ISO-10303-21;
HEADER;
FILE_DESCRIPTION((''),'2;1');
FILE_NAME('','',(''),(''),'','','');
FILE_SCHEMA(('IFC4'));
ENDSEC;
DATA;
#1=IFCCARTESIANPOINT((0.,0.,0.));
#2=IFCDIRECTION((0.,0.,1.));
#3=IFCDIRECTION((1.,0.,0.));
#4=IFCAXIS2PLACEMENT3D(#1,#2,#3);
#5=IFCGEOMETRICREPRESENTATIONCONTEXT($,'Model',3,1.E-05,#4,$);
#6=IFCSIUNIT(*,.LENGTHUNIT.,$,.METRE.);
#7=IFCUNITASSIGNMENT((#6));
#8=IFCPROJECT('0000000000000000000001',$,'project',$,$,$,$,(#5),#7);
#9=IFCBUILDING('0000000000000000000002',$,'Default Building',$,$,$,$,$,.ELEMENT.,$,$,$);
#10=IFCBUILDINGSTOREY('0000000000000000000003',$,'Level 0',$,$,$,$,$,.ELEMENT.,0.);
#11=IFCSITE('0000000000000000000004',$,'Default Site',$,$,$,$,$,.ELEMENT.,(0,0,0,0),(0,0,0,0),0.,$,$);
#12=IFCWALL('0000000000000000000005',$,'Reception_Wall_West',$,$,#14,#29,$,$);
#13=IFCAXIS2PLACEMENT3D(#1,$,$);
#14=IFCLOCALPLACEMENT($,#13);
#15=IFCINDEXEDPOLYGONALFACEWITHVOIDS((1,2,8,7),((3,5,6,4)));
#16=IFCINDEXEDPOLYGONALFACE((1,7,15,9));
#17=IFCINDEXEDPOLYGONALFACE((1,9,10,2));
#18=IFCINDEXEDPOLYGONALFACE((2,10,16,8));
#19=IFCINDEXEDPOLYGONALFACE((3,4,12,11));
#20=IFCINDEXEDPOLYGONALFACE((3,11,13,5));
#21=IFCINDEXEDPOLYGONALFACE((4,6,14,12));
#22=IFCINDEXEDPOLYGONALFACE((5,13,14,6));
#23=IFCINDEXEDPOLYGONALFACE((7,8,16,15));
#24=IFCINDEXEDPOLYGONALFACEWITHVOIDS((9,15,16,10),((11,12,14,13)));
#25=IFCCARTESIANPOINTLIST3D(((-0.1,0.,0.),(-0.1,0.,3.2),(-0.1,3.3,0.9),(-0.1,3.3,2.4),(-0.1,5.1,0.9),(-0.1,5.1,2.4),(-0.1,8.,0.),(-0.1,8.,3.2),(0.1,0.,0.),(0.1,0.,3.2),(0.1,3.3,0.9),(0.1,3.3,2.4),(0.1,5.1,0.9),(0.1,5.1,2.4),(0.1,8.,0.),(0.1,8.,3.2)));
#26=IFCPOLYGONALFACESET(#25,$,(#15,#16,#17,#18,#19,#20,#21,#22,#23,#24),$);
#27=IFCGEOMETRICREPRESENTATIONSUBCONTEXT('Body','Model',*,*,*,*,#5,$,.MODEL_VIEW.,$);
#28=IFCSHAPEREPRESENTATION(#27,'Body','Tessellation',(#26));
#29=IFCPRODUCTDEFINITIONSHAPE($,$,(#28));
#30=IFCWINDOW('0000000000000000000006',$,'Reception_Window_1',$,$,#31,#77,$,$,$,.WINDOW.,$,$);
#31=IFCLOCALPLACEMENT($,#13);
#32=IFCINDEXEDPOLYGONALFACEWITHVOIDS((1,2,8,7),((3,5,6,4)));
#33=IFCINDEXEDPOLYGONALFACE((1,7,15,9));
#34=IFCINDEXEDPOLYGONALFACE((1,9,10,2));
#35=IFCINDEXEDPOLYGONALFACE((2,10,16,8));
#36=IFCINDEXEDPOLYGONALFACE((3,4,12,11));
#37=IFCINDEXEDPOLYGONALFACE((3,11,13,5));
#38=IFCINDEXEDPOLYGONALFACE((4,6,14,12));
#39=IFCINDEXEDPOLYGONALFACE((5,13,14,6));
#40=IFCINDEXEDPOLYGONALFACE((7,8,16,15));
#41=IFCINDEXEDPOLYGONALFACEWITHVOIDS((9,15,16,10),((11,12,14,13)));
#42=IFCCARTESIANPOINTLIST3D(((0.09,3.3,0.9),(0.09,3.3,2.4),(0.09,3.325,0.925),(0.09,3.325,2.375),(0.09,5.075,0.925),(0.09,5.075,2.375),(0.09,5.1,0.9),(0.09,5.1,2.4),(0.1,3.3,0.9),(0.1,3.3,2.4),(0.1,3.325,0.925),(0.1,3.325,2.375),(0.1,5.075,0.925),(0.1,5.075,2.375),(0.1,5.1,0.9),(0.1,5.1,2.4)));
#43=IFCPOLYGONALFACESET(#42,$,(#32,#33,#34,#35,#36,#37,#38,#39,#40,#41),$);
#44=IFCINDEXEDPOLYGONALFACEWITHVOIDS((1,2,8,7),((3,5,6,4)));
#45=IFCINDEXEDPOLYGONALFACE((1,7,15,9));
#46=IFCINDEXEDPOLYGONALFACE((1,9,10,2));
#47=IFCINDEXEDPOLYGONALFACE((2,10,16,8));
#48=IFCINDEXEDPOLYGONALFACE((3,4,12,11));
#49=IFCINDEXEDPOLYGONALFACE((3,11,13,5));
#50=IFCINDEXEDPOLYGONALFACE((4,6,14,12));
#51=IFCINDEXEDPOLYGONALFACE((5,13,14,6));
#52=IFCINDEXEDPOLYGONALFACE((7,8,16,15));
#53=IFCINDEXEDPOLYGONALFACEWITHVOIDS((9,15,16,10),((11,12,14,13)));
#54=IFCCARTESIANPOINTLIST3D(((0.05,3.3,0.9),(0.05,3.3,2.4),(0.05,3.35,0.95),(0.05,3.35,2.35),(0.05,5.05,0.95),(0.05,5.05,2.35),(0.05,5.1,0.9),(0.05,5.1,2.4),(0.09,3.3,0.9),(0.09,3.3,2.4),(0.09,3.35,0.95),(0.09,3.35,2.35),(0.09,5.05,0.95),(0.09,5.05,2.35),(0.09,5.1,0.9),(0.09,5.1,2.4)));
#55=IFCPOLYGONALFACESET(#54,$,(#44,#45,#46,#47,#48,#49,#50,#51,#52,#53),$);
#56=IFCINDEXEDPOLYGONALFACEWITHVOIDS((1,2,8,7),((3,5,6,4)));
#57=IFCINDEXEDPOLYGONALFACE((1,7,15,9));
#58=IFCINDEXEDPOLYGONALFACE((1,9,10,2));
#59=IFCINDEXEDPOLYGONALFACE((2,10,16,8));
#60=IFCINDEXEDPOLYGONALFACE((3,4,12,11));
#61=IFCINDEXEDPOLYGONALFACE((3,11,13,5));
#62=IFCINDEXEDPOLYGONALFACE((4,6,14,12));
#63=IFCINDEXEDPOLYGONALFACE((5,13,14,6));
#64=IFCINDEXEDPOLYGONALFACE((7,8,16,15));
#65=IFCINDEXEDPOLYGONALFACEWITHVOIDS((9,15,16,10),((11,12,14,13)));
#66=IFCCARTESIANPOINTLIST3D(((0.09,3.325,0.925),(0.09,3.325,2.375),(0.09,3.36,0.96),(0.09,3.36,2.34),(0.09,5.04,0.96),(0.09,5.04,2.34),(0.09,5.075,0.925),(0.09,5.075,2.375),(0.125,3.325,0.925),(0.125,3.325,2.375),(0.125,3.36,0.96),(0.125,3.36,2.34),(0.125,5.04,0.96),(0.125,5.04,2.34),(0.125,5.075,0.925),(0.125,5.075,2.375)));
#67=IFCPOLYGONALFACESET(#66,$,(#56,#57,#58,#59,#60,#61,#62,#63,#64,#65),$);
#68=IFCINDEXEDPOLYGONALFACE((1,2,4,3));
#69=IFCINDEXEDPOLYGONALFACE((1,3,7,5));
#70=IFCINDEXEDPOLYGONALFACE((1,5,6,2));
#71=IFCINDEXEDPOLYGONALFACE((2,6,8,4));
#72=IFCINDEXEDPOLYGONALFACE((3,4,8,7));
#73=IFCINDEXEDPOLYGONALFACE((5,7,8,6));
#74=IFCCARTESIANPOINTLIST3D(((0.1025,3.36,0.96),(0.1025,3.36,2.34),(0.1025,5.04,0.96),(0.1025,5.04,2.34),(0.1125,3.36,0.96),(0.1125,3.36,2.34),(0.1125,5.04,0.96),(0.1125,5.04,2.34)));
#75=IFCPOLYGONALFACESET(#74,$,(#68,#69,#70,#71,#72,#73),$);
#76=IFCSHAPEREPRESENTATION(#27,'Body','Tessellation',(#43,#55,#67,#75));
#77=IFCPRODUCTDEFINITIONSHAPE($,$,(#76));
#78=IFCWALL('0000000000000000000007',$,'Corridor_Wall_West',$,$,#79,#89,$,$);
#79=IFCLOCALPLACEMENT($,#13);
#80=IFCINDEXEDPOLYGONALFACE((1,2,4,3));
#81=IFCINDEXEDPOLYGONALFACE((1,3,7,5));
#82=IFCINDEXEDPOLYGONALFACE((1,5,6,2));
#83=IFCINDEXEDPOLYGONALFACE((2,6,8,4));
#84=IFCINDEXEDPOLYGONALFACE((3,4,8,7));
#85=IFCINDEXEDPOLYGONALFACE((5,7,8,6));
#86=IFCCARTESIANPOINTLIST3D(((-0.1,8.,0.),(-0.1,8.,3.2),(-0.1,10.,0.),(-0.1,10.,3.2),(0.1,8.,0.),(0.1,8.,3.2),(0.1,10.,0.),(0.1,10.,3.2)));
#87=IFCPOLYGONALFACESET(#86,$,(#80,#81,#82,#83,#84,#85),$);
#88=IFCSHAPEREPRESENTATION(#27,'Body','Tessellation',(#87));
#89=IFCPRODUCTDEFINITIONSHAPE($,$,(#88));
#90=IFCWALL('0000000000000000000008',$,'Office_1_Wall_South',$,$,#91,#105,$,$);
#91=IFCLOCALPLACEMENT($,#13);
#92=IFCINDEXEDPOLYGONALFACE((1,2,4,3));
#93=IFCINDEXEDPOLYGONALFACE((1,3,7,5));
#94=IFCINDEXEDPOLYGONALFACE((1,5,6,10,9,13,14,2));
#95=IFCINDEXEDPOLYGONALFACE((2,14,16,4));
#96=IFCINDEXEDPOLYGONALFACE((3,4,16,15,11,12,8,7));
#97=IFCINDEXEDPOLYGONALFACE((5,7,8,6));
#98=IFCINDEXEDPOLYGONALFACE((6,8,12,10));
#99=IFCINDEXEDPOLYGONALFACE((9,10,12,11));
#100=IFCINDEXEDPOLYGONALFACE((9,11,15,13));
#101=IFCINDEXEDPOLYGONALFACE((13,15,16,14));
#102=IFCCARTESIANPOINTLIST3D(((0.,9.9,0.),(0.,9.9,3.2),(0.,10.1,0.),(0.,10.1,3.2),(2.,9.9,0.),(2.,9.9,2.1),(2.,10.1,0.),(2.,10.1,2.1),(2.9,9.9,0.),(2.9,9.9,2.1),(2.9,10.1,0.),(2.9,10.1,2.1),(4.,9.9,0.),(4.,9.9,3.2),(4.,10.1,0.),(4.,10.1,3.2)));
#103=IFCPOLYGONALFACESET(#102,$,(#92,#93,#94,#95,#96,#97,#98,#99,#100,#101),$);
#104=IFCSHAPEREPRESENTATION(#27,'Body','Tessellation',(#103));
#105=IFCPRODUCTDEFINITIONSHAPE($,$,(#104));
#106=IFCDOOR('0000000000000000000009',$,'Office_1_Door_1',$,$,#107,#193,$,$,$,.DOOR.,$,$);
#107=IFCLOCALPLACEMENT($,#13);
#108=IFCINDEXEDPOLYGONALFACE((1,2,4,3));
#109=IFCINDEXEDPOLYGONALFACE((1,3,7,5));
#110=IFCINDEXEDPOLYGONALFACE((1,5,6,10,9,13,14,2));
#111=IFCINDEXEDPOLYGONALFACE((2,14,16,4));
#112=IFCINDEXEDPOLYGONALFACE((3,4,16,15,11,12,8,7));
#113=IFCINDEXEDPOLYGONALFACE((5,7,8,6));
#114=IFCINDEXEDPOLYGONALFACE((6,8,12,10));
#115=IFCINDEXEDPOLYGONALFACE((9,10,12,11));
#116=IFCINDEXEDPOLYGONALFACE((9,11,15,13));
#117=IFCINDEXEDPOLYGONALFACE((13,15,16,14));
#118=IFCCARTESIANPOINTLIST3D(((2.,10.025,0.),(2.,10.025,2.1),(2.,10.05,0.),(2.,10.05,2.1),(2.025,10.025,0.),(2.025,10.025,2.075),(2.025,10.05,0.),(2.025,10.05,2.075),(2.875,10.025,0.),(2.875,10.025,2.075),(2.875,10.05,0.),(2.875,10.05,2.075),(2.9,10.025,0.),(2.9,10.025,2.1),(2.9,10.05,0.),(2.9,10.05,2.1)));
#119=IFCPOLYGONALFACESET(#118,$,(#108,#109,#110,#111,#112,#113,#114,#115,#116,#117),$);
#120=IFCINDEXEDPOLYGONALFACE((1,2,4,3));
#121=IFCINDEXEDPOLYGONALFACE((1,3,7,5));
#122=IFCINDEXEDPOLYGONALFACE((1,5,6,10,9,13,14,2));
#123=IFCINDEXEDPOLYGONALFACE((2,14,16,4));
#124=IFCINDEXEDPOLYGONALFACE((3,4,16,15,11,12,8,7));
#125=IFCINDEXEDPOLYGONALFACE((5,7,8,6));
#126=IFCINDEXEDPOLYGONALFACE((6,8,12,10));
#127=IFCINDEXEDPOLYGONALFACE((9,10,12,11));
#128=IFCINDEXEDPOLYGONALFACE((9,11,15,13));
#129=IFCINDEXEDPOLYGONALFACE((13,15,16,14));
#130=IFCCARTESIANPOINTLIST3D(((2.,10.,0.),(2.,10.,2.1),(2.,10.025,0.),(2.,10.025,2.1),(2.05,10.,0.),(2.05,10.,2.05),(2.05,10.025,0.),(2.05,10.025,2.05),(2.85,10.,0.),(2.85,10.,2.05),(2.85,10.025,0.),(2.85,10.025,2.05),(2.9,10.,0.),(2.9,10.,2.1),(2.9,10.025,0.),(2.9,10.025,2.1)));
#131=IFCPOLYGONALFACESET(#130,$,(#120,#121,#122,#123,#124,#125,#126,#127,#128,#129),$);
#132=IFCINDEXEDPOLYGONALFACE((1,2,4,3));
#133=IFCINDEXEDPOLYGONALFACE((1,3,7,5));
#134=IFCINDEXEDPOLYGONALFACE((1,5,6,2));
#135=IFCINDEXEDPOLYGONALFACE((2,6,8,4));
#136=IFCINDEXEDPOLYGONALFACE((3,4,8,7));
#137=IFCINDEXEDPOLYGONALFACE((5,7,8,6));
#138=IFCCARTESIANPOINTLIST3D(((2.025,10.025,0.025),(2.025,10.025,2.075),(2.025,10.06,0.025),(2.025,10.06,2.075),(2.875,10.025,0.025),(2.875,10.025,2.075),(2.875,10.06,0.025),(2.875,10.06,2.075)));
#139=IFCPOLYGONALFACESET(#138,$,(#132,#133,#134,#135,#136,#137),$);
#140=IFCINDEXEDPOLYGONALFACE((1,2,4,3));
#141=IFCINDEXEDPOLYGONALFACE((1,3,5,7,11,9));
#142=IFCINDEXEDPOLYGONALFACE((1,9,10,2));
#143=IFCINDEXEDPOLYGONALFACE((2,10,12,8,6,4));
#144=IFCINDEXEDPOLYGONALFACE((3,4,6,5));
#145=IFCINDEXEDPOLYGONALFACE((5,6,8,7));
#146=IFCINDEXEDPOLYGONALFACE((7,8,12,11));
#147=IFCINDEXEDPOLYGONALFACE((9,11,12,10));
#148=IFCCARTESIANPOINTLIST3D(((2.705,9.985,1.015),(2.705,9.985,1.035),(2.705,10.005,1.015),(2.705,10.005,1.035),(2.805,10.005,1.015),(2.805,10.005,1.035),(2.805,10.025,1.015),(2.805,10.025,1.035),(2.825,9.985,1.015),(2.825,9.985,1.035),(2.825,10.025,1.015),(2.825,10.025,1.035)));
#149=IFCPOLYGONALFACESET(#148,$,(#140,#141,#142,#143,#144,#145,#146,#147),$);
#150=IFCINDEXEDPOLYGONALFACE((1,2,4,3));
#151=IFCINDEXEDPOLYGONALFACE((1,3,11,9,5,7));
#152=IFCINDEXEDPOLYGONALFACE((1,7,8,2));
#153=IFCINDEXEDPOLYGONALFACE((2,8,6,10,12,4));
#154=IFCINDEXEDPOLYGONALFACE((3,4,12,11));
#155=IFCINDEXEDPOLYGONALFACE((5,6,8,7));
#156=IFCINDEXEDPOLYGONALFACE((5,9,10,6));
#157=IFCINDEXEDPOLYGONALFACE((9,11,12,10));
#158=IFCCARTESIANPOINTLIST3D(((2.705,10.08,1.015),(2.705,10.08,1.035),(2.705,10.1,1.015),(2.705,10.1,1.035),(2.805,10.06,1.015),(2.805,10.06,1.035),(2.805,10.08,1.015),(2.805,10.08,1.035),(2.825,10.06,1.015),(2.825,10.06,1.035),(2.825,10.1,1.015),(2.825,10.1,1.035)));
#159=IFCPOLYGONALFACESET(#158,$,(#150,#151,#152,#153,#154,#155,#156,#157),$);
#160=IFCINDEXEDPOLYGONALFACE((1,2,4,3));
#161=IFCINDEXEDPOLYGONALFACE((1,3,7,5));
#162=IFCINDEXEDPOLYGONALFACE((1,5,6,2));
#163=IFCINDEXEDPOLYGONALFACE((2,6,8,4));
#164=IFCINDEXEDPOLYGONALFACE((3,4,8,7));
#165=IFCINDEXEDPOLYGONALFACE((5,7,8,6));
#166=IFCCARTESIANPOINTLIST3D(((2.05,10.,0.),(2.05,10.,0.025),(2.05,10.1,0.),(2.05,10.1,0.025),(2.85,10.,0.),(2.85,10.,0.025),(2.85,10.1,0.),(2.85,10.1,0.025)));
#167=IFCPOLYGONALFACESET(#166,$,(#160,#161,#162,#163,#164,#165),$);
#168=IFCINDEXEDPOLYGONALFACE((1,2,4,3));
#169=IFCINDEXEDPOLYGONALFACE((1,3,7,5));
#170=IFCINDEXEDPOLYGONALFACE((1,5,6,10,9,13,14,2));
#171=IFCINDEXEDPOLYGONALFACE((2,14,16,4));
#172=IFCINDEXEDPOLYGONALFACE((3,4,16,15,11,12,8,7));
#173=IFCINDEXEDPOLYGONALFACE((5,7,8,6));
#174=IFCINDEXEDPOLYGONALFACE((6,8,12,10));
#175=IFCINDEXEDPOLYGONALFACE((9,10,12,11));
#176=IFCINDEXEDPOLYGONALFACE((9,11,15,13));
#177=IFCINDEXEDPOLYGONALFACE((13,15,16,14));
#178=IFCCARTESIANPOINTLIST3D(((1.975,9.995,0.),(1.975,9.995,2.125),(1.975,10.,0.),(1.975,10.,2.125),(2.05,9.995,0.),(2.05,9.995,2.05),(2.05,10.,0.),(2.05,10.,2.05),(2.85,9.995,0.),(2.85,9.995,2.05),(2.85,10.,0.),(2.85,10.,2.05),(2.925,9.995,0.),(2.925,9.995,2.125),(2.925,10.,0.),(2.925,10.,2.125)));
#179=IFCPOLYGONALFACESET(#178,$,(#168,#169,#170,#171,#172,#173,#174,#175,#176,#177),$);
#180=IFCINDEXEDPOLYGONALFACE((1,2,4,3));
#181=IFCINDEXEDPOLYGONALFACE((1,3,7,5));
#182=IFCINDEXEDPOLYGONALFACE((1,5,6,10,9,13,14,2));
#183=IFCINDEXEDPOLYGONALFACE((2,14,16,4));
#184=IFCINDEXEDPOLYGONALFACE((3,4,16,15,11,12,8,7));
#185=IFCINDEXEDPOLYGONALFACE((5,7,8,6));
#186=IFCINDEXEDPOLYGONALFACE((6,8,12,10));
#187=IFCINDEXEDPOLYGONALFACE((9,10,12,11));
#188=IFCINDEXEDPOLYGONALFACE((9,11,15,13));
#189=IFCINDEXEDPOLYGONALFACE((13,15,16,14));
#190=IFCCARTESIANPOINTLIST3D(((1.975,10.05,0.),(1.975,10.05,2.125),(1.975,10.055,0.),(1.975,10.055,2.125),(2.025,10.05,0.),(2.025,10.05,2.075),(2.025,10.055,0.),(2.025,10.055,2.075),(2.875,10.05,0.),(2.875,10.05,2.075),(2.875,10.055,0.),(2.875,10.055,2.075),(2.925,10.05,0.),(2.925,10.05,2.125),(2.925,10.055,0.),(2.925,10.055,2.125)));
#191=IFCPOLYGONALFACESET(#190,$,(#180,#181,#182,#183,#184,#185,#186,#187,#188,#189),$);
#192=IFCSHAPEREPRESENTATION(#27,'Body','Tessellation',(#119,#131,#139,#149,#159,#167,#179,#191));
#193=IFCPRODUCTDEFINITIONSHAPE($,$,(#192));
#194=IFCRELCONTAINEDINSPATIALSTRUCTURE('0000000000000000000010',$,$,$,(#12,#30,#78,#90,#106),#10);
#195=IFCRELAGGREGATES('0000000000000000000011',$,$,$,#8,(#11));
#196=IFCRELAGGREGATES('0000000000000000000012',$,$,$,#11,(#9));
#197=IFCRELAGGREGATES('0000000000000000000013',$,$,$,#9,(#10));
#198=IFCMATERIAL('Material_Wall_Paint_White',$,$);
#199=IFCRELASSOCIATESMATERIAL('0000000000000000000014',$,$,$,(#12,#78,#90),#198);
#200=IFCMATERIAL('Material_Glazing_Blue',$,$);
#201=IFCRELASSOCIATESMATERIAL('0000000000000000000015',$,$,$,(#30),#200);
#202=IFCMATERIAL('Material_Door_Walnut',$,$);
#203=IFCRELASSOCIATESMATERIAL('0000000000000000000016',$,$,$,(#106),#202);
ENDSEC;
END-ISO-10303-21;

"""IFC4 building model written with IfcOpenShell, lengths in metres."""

from ifc_helpers import new_model, si_unit, frame, origin_with_axes, place, context, subcontext, project, spatial, line, indexed_curve, outline, extrude, material, element, fill, save


model = new_model("IFC4")

# Units and contexts
model_context = context("Model", 3, precision=1e-05, world=origin_with_axes())
body_context = subcontext(model_context, "Body", "Model", "MODEL_VIEW")
ifc_project = project(units=[si_unit("LENGTHUNIT", "METRE")], contexts=[model_context])

# Site, building, storey
site = spatial("IfcSite", under=ifc_project, Name="Default Site", CompositionType="ELEMENT", RefLatitude=(0, 0, 0, 0), RefLongitude=(0, 0, 0, 0), RefElevation=0.0)
building = spatial("IfcBuilding", under=site, Name="Default Building", CompositionType="ELEMENT")
storey = spatial("IfcBuildingStorey", under=building, Name="Level 0", CompositionType="ELEMENT", Elevation=0.0)

# Shared definitions
ifc_material_1 = material(Name="Material_Wall_Paint_White")
ifc_material_2 = material(Name="Material_Door_Walnut")

# Wall, opening, window
wall_1_placement = place(None, frame((0.0, 8.0, 0.0), z_axis=(0.0, 0.0, 1.0), x_axis=(0.0, -1.0, 0.0)))
wall_1 = element("IfcWall", 1, at=wall_1_placement, inside=storey, material=ifc_material_1, Name="Reception_Wall_West", context=body_context, shape_type="SweptSolid", body=[
    extrude(outline(indexed_curve([(0.0, 0.0), (0.0, 0.2), (8.0, 0.2), (8.0, 0.0), (0.0, 0.0)], self_intersect=False)), frame((0.0, -0.1, 0.0), z_axis=(0.0, 0.0, 1.0), x_axis=(1.0, 0.0, 0.0)), (0.0, 0.0, 1.0), 3.2),
])
opening_1_placement = place(wall_1_placement, frame((2.9, -0.5, 0.9), z_axis=(0.0, 0.0, 1.0), x_axis=(1.0, 0.0, 0.0)))
opening_1 = element("IfcOpeningElement", 2, at=opening_1_placement, inside=storey, cuts=wall_1, PredefinedType="OPENING", context=body_context, shape_type="SweptSolid", body=[
    extrude(outline(indexed_curve([(0.0, 0.0), (0.0, 1.0), (1.8, 1.0), (1.8, 0.0), (0.0, 0.0)], self_intersect=False)), origin_with_axes(), (0.0, 0.0, 1.0), 1.5),
])
ifc_material_3 = material(Name="Material_Glazing_Blue")
window_placement = place(None, frame((0.0, 5.1, 0.9), z_axis=(0.0, 0.0, 1.0), x_axis=(0.0, -1.0, 0.0)))
window = element("IfcWindow", 3, at=window_placement, inside=storey, material=ifc_material_3, Name="Reception_Window_1", PredefinedType="WINDOW", context=body_context, shape_type="SweptSolid", body=[
    extrude(outline(indexed_curve([(0.0, 0.0), (1.8, 0.0), (1.8, 1.5), (0.0, 1.5)], segments=[line(1, 2, 3, 4, 1)]), holes=[indexed_curve([(0.025, 0.025), (1.775, 0.025), (1.775, 1.475), (0.025, 1.475)], segments=[line(1, 2, 3, 4, 1)])]), frame((0.0, 0.09, 0.0), z_axis=(0.0, -1.0, 0.0), x_axis=(1.0, 0.0, 0.0)), (0.0, 0.0, -1.0), 0.01),
    extrude(outline(indexed_curve([(0.0, 0.0), (1.8, 0.0), (1.8, 1.5), (0.0, 1.5)], segments=[line(1, 2, 3, 4, 1)]), holes=[indexed_curve([(0.05, 0.05), (1.75, 0.05), (1.75, 1.45), (0.05, 1.45)], segments=[line(1, 2, 3, 4, 1)])]), frame((0.0, 0.05, 0.0), z_axis=(0.0, -1.0, 0.0), x_axis=(1.0, 0.0, 0.0)), (0.0, 0.0, -1.0), 0.04),
    extrude(outline(indexed_curve([(0.0, 0.0), (1.75, 0.0), (1.75, 1.45), (0.0, 1.45)], segments=[line(1, 2, 3, 4, 1)]), holes=[indexed_curve([(0.035, 0.035), (1.715, 0.035), (1.715, 1.415), (0.035, 1.415)], segments=[line(1, 2, 3, 4, 1)])]), frame((0.025, 0.09, 0.025), z_axis=(0.0, -1.0, 0.0), x_axis=(1.0, 0.0, 0.0)), (0.0, 0.0, -1.0), 0.035),
    extrude(outline(indexed_curve([(0.035, 0.035), (1.715, 0.035), (1.715, 1.415), (0.035, 1.415)], segments=[line(1, 2, 3, 4, 1)])), frame((0.025, 0.1025, 0.025), z_axis=(0.0, -1.0, 0.0), x_axis=(1.0, 0.0, 0.0)), (0.0, 0.0, -1.0), 0.01),
])
fill(opening_1, window)

# Wall
wall_2_placement = place(None, frame((0.0, 10.0, 0.0), z_axis=(0.0, 0.0, 1.0), x_axis=(0.0, -1.0, 0.0)))
element("IfcWall", 4, at=wall_2_placement, inside=storey, material=ifc_material_1, Name="Corridor_Wall_West", context=body_context, shape_type="SweptSolid", body=[
    extrude(outline(indexed_curve([(0.0, 0.0), (0.0, 0.2), (2.0, 0.2), (2.0, 0.0), (0.0, 0.0)], self_intersect=False)), frame((0.0, -0.1, 0.0), z_axis=(0.0, 0.0, 1.0), x_axis=(1.0, 0.0, 0.0)), (0.0, 0.0, 1.0), 3.2),
])

# Wall, opening, door
wall_3_placement = place(None, frame((0.0, 10.0, 0.0), z_axis=(0.0, 0.0, 1.0), x_axis=(1.0, 0.0, 0.0)))
wall_3 = element("IfcWall", 5, at=wall_3_placement, inside=storey, material=ifc_material_1, Name="Office_1_Wall_South", context=body_context, shape_type="SweptSolid", body=[
    extrude(outline(indexed_curve([(0.0, 0.0), (0.0, 0.2), (4.0, 0.2), (4.0, 0.0), (0.0, 0.0)], self_intersect=False)), frame((0.0, -0.1, 0.0), z_axis=(0.0, 0.0, 1.0), x_axis=(1.0, 0.0, 0.0)), (0.0, 0.0, 1.0), 3.2),
])
opening_2_placement = place(wall_3_placement, frame((2.0, -0.5, 0.0), z_axis=(0.0, 0.0, 1.0), x_axis=(1.0, 0.0, 0.0)))
opening_2 = element("IfcOpeningElement", 6, at=opening_2_placement, inside=storey, cuts=wall_3, PredefinedType="OPENING", context=body_context, shape_type="SweptSolid", body=[
    extrude(outline(indexed_curve([(0.0, 0.0), (0.0, 1.0), (0.9, 1.0), (0.9, 0.0), (0.0, 0.0)], self_intersect=False)), origin_with_axes(), (0.0, 0.0, 1.0), 2.1),
])
door_1_placement = place(None, frame((2.0, 10.0, 0.0), z_axis=(0.0, 0.0, 1.0), x_axis=(1.0, 0.0, 0.0)))
door_1 = element("IfcDoor", 7, at=door_1_placement, inside=storey, material=ifc_material_2, Name="Office_1_Door_1", PredefinedType="DOOR", context=body_context, shape_type="SweptSolid", body=[
    extrude(outline(indexed_curve([(0.0, 0.0), (0.0, 2.1), (0.9, 2.1), (0.9, 0.0), (0.875, 0.0), (0.875, 2.075), (0.025, 2.075), (0.025, 0.0)], segments=[line(1, 2, 3, 4, 5, 6, 7, 8, 1)])), frame((0.0, 0.025, 0.0), z_axis=(0.0, -1.0, 0.0), x_axis=(1.0, 0.0, 0.0)), (0.0, 0.0, -1.0), 0.025),
    extrude(outline(indexed_curve([(0.0, 0.0), (0.0, 2.1), (0.9, 2.1), (0.9, 0.0), (0.85, 0.0), (0.85, 2.05), (0.05, 2.05), (0.05, 0.0)], segments=[line(1, 2, 3, 4, 5, 6, 7, 8, 1)])), frame((0.0, 0.0, 0.0), z_axis=(0.0, -1.0, 0.0), x_axis=(1.0, 0.0, 0.0)), (0.0, 0.0, -1.0), 0.025),
    extrude(outline(indexed_curve([(0.0, 0.0), (0.85, 0.0), (0.85, 0.035), (0.0, 0.035)], segments=[line(1, 2, 3, 4, 1)])), frame((0.025, 0.025, 0.025), z_axis=(0.0, 0.0, 1.0), x_axis=(1.0, 0.0, 0.0)), (0.0, 0.0, 1.0), 2.05),
    extrude(outline(indexed_curve([(0.0, 0.0), (0.0, -0.04), (-0.12, -0.04), (-0.12, -0.02), (-0.02, -0.02), (-0.02, 0.0)], segments=[line(1, 2, 3, 4, 5, 6, 1)])), frame((0.825, 0.025, 1.015), z_axis=(0.0, 0.0, 1.0), x_axis=(1.0, 0.0, 0.0)), (0.0, 0.0, 1.0), 0.02),
    extrude(outline(indexed_curve([(0.0, 0.0), (0.0, 0.04), (-0.12, 0.04), (-0.12, 0.02), (-0.02, 0.02), (-0.02, 0.0)], segments=[line(1, 2, 3, 4, 5, 6, 1)])), frame((0.825, 0.06, 1.015), z_axis=(0.0, 0.0, 1.0), x_axis=(1.0, 0.0, 0.0)), (0.0, 0.0, 1.0), 0.02),
    extrude(outline(indexed_curve([(0.0, 0.0), (0.8, 0.0), (0.8, 0.1), (0.0, 0.1)], segments=[line(1, 2, 3, 4, 1)])), frame((0.05, 0.0, 0.0), z_axis=(0.0, 0.0, 1.0), x_axis=(1.0, 0.0, 0.0)), (0.0, 0.0, 1.0), 0.025),
    extrude(outline(indexed_curve([(0.0, 0.0), (0.0, 2.125), (0.95, 2.125), (0.95, 0.0), (0.875, 0.0), (0.875, 2.05), (0.075, 2.05), (0.075, 0.0)], segments=[line(1, 2, 3, 4, 5, 6, 7, 8, 1)])), frame((-0.025, -0.005, 0.0), z_axis=(0.0, -1.0, 0.0), x_axis=(1.0, 0.0, 0.0)), (0.0, 0.0, -1.0), 0.005),
    extrude(outline(indexed_curve([(0.0, 0.0), (0.0, 2.125), (0.95, 2.125), (0.95, 0.0), (0.9, 0.0), (0.9, 2.075), (0.05, 2.075), (0.05, 0.0)], segments=[line(1, 2, 3, 4, 5, 6, 7, 8, 1)])), frame((-0.025, 0.05, 0.0), z_axis=(0.0, -1.0, 0.0), x_axis=(1.0, 0.0, 0.0)), (0.0, 0.0, -1.0), 0.005),
])
fill(opening_2, door_1)

save(model, "model.ifc")
